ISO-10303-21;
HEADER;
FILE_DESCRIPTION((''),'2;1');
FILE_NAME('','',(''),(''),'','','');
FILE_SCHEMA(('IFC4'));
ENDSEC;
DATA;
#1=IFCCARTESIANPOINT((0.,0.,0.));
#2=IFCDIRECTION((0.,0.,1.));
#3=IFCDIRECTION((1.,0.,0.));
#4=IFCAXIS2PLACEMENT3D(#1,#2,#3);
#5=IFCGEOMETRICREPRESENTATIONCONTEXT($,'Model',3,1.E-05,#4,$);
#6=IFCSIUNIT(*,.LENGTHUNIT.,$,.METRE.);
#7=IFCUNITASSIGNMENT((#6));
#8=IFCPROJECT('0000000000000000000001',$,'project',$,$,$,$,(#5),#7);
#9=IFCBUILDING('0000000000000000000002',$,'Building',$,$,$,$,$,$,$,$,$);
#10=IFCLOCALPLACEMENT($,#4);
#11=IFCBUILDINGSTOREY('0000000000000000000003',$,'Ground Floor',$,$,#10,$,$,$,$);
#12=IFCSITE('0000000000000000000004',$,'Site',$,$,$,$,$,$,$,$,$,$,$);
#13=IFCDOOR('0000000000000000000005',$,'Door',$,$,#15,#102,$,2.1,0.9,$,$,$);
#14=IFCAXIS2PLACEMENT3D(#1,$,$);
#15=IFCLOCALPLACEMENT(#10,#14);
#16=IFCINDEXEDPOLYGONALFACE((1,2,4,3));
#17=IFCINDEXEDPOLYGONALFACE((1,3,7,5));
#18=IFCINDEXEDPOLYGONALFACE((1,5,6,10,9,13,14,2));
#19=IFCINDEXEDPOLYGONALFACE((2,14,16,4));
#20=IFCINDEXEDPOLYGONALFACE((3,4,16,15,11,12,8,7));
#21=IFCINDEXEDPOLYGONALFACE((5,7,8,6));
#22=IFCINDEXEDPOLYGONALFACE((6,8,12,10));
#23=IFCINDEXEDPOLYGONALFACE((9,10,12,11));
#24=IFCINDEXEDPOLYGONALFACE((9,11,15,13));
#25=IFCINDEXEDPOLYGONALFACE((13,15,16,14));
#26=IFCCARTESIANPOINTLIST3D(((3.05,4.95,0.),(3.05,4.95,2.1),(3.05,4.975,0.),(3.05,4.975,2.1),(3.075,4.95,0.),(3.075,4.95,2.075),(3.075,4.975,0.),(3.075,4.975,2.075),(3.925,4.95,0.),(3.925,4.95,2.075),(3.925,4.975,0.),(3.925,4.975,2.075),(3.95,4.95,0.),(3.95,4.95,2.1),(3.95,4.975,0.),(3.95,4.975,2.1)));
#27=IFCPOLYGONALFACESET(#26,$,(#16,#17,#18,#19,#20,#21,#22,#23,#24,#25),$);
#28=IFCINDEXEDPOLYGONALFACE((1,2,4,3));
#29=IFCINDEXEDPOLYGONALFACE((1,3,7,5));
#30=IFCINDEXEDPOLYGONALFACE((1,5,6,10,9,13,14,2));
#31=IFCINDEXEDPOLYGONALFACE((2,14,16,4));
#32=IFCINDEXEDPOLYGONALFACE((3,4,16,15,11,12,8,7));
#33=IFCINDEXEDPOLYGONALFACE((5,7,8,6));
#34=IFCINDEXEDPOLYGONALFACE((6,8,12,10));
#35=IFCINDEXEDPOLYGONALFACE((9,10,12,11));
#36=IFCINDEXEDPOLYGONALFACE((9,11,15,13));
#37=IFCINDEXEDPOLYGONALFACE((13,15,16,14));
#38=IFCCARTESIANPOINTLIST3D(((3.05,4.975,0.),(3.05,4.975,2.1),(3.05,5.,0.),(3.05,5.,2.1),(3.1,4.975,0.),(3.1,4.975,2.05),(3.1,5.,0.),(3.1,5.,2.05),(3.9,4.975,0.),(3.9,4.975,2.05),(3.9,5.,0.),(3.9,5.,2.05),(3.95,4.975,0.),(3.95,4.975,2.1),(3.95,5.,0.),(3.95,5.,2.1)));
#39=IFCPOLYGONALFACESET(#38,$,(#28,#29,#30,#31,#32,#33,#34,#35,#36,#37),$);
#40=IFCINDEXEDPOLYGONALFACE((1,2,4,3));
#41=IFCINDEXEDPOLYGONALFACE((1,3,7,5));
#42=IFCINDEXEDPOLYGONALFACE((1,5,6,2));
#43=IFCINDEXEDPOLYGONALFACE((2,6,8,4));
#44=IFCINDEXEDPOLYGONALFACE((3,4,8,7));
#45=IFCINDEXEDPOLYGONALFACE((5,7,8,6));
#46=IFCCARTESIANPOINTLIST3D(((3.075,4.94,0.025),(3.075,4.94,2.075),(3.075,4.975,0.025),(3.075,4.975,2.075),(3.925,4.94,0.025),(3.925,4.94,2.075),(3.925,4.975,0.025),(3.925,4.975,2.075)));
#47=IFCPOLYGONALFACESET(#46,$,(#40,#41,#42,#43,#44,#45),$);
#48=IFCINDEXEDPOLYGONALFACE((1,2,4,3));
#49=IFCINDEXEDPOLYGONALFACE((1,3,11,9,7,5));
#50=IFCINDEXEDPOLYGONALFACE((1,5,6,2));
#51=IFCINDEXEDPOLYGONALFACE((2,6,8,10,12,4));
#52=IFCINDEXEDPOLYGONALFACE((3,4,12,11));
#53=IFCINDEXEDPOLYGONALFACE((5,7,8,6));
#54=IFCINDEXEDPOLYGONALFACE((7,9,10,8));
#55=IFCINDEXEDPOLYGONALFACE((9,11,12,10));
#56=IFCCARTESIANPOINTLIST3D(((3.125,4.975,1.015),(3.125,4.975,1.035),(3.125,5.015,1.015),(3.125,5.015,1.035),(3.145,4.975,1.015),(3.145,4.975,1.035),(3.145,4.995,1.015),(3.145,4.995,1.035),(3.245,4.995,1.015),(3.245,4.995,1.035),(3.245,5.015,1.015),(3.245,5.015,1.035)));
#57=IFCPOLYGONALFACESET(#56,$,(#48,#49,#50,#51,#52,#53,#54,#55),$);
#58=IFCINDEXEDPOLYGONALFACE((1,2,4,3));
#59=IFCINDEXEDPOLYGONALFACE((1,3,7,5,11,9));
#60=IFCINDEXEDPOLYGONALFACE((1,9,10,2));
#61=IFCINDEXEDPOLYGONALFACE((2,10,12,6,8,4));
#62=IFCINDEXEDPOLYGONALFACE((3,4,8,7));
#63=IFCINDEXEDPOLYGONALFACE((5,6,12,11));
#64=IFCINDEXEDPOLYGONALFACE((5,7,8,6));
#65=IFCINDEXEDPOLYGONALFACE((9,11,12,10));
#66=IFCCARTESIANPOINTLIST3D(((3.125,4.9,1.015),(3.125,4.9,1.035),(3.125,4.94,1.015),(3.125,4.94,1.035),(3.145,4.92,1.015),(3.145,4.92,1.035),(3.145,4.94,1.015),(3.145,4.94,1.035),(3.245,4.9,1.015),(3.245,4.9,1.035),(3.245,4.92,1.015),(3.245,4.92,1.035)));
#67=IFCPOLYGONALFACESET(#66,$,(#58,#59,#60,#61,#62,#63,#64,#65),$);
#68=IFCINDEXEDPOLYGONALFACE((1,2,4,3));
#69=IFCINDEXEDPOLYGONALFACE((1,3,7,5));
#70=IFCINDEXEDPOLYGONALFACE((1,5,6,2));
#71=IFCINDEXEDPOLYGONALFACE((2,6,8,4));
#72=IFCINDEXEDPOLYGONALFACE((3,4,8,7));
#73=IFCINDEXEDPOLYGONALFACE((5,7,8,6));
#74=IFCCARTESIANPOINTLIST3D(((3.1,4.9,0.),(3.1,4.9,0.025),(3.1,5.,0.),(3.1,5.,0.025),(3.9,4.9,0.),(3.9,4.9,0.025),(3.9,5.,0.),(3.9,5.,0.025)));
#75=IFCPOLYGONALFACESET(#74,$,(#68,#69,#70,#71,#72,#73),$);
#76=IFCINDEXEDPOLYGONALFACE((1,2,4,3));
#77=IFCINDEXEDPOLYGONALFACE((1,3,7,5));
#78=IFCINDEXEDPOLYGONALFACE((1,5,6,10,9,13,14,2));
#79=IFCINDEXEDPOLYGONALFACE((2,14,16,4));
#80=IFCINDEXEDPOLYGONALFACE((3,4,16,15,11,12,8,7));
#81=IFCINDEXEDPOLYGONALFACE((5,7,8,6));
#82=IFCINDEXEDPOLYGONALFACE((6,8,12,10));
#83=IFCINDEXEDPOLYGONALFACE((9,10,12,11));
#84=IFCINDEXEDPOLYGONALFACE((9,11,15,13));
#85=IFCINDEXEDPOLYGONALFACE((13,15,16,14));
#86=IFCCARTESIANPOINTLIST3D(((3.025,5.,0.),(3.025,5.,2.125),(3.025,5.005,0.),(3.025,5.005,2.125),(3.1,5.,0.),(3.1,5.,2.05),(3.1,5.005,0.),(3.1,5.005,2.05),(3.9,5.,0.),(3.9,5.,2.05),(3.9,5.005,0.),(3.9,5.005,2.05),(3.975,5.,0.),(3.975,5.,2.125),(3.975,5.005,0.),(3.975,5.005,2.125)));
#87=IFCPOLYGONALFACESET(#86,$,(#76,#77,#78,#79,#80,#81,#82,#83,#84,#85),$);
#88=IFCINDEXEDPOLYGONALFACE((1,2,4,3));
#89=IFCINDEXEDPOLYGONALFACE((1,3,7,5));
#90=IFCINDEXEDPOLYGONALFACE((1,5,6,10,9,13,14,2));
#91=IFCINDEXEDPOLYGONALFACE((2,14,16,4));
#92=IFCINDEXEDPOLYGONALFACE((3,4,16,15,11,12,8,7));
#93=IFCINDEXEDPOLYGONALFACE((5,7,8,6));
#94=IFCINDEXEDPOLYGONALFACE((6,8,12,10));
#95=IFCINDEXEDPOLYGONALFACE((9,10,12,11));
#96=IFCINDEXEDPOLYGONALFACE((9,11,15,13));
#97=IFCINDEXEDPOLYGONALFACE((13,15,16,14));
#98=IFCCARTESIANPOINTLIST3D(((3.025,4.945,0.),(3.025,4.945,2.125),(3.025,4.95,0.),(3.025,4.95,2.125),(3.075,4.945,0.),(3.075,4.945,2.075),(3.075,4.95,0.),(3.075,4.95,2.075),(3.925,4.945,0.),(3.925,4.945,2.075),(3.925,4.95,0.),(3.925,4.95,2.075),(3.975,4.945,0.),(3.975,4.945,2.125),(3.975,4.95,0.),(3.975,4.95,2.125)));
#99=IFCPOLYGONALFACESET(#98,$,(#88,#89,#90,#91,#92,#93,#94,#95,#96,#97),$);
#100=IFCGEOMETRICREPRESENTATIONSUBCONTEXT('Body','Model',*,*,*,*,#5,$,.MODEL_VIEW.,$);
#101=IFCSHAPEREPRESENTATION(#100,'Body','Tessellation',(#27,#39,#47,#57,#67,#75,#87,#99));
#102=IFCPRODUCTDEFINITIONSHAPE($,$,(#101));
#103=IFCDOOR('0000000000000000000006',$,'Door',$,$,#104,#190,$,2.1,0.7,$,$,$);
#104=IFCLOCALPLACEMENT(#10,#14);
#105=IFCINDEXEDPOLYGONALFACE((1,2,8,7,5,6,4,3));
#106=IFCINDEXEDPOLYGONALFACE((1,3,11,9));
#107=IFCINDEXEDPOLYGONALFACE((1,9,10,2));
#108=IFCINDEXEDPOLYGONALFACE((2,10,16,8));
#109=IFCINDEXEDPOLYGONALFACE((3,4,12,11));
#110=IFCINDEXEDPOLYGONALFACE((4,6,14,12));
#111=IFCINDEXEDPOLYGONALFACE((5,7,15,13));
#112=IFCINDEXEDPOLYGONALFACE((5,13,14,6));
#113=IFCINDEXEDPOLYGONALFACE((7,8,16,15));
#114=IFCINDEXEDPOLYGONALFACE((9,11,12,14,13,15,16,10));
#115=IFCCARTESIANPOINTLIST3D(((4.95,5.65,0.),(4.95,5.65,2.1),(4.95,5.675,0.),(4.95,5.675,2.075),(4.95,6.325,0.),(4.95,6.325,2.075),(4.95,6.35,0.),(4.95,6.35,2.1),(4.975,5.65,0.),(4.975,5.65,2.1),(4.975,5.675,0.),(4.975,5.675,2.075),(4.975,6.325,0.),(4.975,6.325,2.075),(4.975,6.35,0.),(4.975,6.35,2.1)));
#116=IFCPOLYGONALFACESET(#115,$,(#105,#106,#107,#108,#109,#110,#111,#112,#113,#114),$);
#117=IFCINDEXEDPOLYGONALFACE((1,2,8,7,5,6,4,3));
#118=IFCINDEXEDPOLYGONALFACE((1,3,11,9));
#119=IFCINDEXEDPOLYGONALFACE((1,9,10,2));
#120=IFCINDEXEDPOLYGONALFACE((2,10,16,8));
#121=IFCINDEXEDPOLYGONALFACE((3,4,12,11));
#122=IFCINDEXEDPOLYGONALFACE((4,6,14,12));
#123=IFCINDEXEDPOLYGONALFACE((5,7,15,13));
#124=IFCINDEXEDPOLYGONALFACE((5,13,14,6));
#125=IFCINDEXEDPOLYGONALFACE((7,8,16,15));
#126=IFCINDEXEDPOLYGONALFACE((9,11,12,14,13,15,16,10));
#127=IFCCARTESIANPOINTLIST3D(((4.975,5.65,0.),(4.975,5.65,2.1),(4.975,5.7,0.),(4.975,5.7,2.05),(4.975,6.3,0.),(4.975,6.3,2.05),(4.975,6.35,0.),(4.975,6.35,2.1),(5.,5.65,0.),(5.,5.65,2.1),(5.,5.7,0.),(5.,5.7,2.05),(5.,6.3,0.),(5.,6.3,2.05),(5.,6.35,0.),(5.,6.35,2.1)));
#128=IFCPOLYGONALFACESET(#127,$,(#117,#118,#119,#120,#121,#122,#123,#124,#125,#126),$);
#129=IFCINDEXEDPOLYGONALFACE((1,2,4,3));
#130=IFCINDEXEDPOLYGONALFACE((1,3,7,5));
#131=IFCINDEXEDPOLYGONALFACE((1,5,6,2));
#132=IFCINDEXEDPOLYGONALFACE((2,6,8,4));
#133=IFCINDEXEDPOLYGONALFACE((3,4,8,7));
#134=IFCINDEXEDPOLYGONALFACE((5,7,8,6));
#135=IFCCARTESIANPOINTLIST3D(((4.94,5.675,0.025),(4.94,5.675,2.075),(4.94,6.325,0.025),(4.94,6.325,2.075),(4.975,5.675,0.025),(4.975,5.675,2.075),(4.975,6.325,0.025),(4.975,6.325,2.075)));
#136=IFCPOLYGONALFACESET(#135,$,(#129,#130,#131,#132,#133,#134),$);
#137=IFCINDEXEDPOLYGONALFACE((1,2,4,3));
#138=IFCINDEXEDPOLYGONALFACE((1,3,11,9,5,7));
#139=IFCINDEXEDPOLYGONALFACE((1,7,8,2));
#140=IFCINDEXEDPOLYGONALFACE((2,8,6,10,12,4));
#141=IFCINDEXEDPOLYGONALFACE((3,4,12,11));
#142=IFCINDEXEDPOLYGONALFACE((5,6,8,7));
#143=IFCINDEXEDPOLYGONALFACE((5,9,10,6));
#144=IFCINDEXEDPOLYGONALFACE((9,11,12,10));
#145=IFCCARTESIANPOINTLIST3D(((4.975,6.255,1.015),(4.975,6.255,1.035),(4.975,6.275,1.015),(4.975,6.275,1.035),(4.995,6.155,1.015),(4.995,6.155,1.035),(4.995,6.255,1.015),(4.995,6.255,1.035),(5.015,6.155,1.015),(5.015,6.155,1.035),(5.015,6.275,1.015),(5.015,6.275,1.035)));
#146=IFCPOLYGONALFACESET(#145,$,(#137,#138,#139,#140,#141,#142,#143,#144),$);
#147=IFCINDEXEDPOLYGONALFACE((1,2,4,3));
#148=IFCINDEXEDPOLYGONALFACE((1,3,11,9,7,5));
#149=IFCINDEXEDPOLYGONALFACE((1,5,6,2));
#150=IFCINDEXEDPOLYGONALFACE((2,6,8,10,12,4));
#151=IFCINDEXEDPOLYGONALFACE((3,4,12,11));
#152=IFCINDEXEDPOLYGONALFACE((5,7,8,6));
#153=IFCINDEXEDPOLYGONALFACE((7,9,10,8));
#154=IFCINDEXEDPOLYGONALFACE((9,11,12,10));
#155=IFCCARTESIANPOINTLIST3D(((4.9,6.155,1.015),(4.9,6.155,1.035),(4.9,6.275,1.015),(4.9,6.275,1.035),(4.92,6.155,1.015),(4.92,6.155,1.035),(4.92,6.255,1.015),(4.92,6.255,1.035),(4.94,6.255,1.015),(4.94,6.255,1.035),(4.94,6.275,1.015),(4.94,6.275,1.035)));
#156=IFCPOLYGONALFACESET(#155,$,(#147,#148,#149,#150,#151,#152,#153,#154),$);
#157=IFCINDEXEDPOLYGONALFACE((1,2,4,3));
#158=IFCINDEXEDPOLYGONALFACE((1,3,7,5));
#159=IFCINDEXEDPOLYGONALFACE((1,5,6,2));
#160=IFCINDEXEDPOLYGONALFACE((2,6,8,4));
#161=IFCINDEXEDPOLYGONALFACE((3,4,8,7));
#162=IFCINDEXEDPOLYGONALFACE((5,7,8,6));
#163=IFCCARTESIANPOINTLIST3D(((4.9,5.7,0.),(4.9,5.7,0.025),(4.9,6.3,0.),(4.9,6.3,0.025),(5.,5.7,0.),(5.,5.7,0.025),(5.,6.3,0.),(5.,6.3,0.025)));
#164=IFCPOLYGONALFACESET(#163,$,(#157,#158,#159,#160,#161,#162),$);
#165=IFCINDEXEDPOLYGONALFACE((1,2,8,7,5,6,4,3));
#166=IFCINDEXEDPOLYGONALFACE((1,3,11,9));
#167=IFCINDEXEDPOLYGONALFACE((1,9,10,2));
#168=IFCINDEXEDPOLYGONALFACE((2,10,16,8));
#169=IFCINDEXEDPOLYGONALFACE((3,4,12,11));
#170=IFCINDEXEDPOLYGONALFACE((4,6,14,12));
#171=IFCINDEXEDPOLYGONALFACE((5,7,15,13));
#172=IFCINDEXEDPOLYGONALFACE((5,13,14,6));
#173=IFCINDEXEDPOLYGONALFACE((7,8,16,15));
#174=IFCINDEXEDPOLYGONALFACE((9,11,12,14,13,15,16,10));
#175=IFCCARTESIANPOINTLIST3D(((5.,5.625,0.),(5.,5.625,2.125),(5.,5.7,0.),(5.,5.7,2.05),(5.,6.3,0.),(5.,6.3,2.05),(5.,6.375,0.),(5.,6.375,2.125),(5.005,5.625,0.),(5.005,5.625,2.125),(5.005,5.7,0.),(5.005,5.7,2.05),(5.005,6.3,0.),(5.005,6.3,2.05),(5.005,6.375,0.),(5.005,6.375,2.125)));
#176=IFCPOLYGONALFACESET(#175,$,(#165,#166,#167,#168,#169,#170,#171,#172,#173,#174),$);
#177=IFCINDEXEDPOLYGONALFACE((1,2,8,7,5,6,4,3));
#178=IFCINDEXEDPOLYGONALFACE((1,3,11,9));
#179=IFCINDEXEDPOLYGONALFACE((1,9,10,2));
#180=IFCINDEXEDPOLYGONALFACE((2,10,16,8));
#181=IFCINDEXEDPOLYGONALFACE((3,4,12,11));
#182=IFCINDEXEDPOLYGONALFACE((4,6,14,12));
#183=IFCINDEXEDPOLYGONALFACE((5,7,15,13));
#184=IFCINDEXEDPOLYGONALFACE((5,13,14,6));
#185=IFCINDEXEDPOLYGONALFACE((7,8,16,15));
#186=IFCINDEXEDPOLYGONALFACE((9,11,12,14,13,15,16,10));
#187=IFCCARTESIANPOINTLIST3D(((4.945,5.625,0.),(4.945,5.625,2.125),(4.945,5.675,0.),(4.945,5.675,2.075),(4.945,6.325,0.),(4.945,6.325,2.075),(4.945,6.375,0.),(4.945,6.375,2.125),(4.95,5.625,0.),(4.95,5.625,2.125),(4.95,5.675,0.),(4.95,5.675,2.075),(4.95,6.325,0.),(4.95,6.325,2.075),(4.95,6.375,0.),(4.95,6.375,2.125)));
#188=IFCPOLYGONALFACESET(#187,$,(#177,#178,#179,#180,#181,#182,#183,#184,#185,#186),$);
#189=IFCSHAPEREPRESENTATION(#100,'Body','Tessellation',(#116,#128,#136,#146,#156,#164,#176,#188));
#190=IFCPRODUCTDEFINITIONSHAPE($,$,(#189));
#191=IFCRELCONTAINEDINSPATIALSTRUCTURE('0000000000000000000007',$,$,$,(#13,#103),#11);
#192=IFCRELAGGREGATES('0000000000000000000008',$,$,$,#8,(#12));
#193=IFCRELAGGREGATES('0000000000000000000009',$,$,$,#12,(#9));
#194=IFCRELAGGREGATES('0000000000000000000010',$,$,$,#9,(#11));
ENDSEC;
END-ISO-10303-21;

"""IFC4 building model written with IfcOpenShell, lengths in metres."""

from ifc_helpers import new_model, si_unit, frame, origin_with_axes, place, context, subcontext, project, spatial, line, indexed_curve, outline, extrude, element, save


model = new_model("IFC4")

# Units and contexts
model_context = context("Model", 3, precision=1e-05, world=origin_with_axes())
body_context = subcontext(model_context, "Body", "Model", "MODEL_VIEW")
ifc_project = project(units=[si_unit("LENGTHUNIT", "METRE")], contexts=[model_context])

# Site, building, storey
site = spatial("IfcSite", under=ifc_project, Name="Site")
building = spatial("IfcBuilding", under=site, Name="Building")
storey_placement = place(None, origin_with_axes())
storey = spatial("IfcBuildingStorey", under=building, at=storey_placement, Name="Ground Floor")

# Doors
door_1_placement = place(storey_placement, frame((3.95, 5.0, 0.0), z_axis=(0.0, 0.0, 1.0), x_axis=(-1.0, 0.0, 0.0)))
element("IfcDoor", 1, at=door_1_placement, inside=storey, Name="Door", OverallHeight=2.1, OverallWidth=0.9, context=body_context, shape_type="SweptSolid", body=[
    extrude(outline(indexed_curve([(0.0, 0.0), (0.0, 2.1), (0.9, 2.1), (0.9, 0.0), (0.875, 0.0), (0.875, 2.075), (0.025, 2.075), (0.025, 0.0)], segments=[line(1, 2, 3, 4, 5, 6, 7, 8, 1)])), frame((0.0, 0.025, 0.0), z_axis=(0.0, -1.0, 0.0), x_axis=(1.0, 0.0, 0.0)), (0.0, 0.0, -1.0), 0.025),
    extrude(outline(indexed_curve([(0.0, 0.0), (0.0, 2.1), (0.9, 2.1), (0.9, 0.0), (0.85, 0.0), (0.85, 2.05), (0.05, 2.05), (0.05, 0.0)], segments=[line(1, 2, 3, 4, 5, 6, 7, 8, 1)])), frame((0.0, 0.0, 0.0), z_axis=(0.0, -1.0, 0.0), x_axis=(1.0, 0.0, 0.0)), (0.0, 0.0, -1.0), 0.025),
    extrude(outline(indexed_curve([(0.0, 0.0), (0.85, 0.0), (0.85, 0.035), (0.0, 0.035)], segments=[line(1, 2, 3, 4, 1)])), frame((0.025, 0.025, 0.025), z_axis=(0.0, 0.0, 1.0), x_axis=(1.0, 0.0, 0.0)), (0.0, 0.0, 1.0), 2.05),
    extrude(outline(indexed_curve([(0.0, 0.0), (0.0, -0.04), (-0.12, -0.04), (-0.12, -0.02), (-0.02, -0.02), (-0.02, 0.0)], segments=[line(1, 2, 3, 4, 5, 6, 1)])), frame((0.825, 0.025, 1.015), z_axis=(0.0, 0.0, 1.0), x_axis=(1.0, 0.0, 0.0)), (0.0, 0.0, 1.0), 0.02),
    extrude(outline(indexed_curve([(0.0, 0.0), (0.0, 0.04), (-0.12, 0.04), (-0.12, 0.02), (-0.02, 0.02), (-0.02, 0.0)], segments=[line(1, 2, 3, 4, 5, 6, 1)])), frame((0.825, 0.06, 1.015), z_axis=(0.0, 0.0, 1.0), x_axis=(1.0, 0.0, 0.0)), (0.0, 0.0, 1.0), 0.02),
    extrude(outline(indexed_curve([(0.0, 0.0), (0.8, 0.0), (0.8, 0.1), (0.0, 0.1)], segments=[line(1, 2, 3, 4, 1)])), frame((0.05, 0.0, 0.0), z_axis=(0.0, 0.0, 1.0), x_axis=(1.0, 0.0, 0.0)), (0.0, 0.0, 1.0), 0.025),
    extrude(outline(indexed_curve([(0.0, 0.0), (0.0, 2.125), (0.95, 2.125), (0.95, 0.0), (0.875, 0.0), (0.875, 2.05), (0.075, 2.05), (0.075, 0.0)], segments=[line(1, 2, 3, 4, 5, 6, 7, 8, 1)])), frame((-0.025, -0.005, 0.0), z_axis=(0.0, -1.0, 0.0), x_axis=(1.0, 0.0, 0.0)), (0.0, 0.0, -1.0), 0.005),
    extrude(outline(indexed_curve([(0.0, 0.0), (0.0, 2.125), (0.95, 2.125), (0.95, 0.0), (0.9, 0.0), (0.9, 2.075), (0.05, 2.075), (0.05, 0.0)], segments=[line(1, 2, 3, 4, 5, 6, 7, 8, 1)])), frame((-0.025, 0.05, 0.0), z_axis=(0.0, -1.0, 0.0), x_axis=(1.0, 0.0, 0.0)), (0.0, 0.0, -1.0), 0.005),
])
door_2_placement = place(storey_placement, frame((5.0, 5.65, 0.0), z_axis=(0.0, 0.0, 1.0), x_axis=(0.0, 1.0, 0.0)))
element("IfcDoor", 2, at=door_2_placement, inside=storey, Name="Door", OverallHeight=2.1, OverallWidth=0.7, context=body_context, shape_type="SweptSolid", body=[
    extrude(outline(indexed_curve([(0.0, 0.0), (0.0, 2.1), (0.7, 2.1), (0.7, 0.0), (0.675, 0.0), (0.675, 2.075), (0.025, 2.075), (0.025, 0.0)], segments=[line(1, 2, 3, 4, 5, 6, 7, 8, 1)])), frame((0.0, 0.025, 0.0), z_axis=(0.0, -1.0, 0.0), x_axis=(1.0, 0.0, 0.0)), (0.0, 0.0, -1.0), 0.025),
    extrude(outline(indexed_curve([(0.0, 0.0), (0.0, 2.1), (0.7, 2.1), (0.7, 0.0), (0.65, 0.0), (0.65, 2.05), (0.05, 2.05), (0.05, 0.0)], segments=[line(1, 2, 3, 4, 5, 6, 7, 8, 1)])), frame((0.0, 0.0, 0.0), z_axis=(0.0, -1.0, 0.0), x_axis=(1.0, 0.0, 0.0)), (0.0, 0.0, -1.0), 0.025),
    extrude(outline(indexed_curve([(0.0, 0.0), (0.65, 0.0), (0.65, 0.035), (0.0, 0.035)], segments=[line(1, 2, 3, 4, 1)])), frame((0.025, 0.025, 0.025), z_axis=(0.0, 0.0, 1.0), x_axis=(1.0, 0.0, 0.0)), (0.0, 0.0, 1.0), 2.05),
    extrude(outline(indexed_curve([(0.0, 0.0), (0.0, -0.04), (-0.12, -0.04), (-0.12, -0.02), (-0.02, -0.02), (-0.02, 0.0)], segments=[line(1, 2, 3, 4, 5, 6, 1)])), frame((0.625, 0.025, 1.015), z_axis=(0.0, 0.0, 1.0), x_axis=(1.0, 0.0, 0.0)), (0.0, 0.0, 1.0), 0.02),
    extrude(outline(indexed_curve([(0.0, 0.0), (0.0, 0.04), (-0.12, 0.04), (-0.12, 0.02), (-0.02, 0.02), (-0.02, 0.0)], segments=[line(1, 2, 3, 4, 5, 6, 1)])), frame((0.625, 0.06, 1.015), z_axis=(0.0, 0.0, 1.0), x_axis=(1.0, 0.0, 0.0)), (0.0, 0.0, 1.0), 0.02),
    extrude(outline(indexed_curve([(0.0, 0.0), (0.6, 0.0), (0.6, 0.1), (0.0, 0.1)], segments=[line(1, 2, 3, 4, 1)])), frame((0.05, 0.0, 0.0), z_axis=(0.0, 0.0, 1.0), x_axis=(1.0, 0.0, 0.0)), (0.0, 0.0, 1.0), 0.025),
    extrude(outline(indexed_curve([(0.0, 0.0), (0.0, 2.125), (0.75, 2.125), (0.75, 0.0), (0.675, 0.0), (0.675, 2.05), (0.075, 2.05), (0.075, 0.0)], segments=[line(1, 2, 3, 4, 5, 6, 7, 8, 1)])), frame((-0.025, -0.005, 0.0), z_axis=(0.0, -1.0, 0.0), x_axis=(1.0, 0.0, 0.0)), (0.0, 0.0, -1.0), 0.005),
    extrude(outline(indexed_curve([(0.0, 0.0), (0.0, 2.125), (0.75, 2.125), (0.75, 0.0), (0.7, 0.0), (0.7, 2.075), (0.05, 2.075), (0.05, 0.0)], segments=[line(1, 2, 3, 4, 5, 6, 7, 8, 1)])), frame((-0.025, 0.05, 0.0), z_axis=(0.0, -1.0, 0.0), x_axis=(1.0, 0.0, 0.0)), (0.0, 0.0, -1.0), 0.005),
])

save(model, "model.ifc")
